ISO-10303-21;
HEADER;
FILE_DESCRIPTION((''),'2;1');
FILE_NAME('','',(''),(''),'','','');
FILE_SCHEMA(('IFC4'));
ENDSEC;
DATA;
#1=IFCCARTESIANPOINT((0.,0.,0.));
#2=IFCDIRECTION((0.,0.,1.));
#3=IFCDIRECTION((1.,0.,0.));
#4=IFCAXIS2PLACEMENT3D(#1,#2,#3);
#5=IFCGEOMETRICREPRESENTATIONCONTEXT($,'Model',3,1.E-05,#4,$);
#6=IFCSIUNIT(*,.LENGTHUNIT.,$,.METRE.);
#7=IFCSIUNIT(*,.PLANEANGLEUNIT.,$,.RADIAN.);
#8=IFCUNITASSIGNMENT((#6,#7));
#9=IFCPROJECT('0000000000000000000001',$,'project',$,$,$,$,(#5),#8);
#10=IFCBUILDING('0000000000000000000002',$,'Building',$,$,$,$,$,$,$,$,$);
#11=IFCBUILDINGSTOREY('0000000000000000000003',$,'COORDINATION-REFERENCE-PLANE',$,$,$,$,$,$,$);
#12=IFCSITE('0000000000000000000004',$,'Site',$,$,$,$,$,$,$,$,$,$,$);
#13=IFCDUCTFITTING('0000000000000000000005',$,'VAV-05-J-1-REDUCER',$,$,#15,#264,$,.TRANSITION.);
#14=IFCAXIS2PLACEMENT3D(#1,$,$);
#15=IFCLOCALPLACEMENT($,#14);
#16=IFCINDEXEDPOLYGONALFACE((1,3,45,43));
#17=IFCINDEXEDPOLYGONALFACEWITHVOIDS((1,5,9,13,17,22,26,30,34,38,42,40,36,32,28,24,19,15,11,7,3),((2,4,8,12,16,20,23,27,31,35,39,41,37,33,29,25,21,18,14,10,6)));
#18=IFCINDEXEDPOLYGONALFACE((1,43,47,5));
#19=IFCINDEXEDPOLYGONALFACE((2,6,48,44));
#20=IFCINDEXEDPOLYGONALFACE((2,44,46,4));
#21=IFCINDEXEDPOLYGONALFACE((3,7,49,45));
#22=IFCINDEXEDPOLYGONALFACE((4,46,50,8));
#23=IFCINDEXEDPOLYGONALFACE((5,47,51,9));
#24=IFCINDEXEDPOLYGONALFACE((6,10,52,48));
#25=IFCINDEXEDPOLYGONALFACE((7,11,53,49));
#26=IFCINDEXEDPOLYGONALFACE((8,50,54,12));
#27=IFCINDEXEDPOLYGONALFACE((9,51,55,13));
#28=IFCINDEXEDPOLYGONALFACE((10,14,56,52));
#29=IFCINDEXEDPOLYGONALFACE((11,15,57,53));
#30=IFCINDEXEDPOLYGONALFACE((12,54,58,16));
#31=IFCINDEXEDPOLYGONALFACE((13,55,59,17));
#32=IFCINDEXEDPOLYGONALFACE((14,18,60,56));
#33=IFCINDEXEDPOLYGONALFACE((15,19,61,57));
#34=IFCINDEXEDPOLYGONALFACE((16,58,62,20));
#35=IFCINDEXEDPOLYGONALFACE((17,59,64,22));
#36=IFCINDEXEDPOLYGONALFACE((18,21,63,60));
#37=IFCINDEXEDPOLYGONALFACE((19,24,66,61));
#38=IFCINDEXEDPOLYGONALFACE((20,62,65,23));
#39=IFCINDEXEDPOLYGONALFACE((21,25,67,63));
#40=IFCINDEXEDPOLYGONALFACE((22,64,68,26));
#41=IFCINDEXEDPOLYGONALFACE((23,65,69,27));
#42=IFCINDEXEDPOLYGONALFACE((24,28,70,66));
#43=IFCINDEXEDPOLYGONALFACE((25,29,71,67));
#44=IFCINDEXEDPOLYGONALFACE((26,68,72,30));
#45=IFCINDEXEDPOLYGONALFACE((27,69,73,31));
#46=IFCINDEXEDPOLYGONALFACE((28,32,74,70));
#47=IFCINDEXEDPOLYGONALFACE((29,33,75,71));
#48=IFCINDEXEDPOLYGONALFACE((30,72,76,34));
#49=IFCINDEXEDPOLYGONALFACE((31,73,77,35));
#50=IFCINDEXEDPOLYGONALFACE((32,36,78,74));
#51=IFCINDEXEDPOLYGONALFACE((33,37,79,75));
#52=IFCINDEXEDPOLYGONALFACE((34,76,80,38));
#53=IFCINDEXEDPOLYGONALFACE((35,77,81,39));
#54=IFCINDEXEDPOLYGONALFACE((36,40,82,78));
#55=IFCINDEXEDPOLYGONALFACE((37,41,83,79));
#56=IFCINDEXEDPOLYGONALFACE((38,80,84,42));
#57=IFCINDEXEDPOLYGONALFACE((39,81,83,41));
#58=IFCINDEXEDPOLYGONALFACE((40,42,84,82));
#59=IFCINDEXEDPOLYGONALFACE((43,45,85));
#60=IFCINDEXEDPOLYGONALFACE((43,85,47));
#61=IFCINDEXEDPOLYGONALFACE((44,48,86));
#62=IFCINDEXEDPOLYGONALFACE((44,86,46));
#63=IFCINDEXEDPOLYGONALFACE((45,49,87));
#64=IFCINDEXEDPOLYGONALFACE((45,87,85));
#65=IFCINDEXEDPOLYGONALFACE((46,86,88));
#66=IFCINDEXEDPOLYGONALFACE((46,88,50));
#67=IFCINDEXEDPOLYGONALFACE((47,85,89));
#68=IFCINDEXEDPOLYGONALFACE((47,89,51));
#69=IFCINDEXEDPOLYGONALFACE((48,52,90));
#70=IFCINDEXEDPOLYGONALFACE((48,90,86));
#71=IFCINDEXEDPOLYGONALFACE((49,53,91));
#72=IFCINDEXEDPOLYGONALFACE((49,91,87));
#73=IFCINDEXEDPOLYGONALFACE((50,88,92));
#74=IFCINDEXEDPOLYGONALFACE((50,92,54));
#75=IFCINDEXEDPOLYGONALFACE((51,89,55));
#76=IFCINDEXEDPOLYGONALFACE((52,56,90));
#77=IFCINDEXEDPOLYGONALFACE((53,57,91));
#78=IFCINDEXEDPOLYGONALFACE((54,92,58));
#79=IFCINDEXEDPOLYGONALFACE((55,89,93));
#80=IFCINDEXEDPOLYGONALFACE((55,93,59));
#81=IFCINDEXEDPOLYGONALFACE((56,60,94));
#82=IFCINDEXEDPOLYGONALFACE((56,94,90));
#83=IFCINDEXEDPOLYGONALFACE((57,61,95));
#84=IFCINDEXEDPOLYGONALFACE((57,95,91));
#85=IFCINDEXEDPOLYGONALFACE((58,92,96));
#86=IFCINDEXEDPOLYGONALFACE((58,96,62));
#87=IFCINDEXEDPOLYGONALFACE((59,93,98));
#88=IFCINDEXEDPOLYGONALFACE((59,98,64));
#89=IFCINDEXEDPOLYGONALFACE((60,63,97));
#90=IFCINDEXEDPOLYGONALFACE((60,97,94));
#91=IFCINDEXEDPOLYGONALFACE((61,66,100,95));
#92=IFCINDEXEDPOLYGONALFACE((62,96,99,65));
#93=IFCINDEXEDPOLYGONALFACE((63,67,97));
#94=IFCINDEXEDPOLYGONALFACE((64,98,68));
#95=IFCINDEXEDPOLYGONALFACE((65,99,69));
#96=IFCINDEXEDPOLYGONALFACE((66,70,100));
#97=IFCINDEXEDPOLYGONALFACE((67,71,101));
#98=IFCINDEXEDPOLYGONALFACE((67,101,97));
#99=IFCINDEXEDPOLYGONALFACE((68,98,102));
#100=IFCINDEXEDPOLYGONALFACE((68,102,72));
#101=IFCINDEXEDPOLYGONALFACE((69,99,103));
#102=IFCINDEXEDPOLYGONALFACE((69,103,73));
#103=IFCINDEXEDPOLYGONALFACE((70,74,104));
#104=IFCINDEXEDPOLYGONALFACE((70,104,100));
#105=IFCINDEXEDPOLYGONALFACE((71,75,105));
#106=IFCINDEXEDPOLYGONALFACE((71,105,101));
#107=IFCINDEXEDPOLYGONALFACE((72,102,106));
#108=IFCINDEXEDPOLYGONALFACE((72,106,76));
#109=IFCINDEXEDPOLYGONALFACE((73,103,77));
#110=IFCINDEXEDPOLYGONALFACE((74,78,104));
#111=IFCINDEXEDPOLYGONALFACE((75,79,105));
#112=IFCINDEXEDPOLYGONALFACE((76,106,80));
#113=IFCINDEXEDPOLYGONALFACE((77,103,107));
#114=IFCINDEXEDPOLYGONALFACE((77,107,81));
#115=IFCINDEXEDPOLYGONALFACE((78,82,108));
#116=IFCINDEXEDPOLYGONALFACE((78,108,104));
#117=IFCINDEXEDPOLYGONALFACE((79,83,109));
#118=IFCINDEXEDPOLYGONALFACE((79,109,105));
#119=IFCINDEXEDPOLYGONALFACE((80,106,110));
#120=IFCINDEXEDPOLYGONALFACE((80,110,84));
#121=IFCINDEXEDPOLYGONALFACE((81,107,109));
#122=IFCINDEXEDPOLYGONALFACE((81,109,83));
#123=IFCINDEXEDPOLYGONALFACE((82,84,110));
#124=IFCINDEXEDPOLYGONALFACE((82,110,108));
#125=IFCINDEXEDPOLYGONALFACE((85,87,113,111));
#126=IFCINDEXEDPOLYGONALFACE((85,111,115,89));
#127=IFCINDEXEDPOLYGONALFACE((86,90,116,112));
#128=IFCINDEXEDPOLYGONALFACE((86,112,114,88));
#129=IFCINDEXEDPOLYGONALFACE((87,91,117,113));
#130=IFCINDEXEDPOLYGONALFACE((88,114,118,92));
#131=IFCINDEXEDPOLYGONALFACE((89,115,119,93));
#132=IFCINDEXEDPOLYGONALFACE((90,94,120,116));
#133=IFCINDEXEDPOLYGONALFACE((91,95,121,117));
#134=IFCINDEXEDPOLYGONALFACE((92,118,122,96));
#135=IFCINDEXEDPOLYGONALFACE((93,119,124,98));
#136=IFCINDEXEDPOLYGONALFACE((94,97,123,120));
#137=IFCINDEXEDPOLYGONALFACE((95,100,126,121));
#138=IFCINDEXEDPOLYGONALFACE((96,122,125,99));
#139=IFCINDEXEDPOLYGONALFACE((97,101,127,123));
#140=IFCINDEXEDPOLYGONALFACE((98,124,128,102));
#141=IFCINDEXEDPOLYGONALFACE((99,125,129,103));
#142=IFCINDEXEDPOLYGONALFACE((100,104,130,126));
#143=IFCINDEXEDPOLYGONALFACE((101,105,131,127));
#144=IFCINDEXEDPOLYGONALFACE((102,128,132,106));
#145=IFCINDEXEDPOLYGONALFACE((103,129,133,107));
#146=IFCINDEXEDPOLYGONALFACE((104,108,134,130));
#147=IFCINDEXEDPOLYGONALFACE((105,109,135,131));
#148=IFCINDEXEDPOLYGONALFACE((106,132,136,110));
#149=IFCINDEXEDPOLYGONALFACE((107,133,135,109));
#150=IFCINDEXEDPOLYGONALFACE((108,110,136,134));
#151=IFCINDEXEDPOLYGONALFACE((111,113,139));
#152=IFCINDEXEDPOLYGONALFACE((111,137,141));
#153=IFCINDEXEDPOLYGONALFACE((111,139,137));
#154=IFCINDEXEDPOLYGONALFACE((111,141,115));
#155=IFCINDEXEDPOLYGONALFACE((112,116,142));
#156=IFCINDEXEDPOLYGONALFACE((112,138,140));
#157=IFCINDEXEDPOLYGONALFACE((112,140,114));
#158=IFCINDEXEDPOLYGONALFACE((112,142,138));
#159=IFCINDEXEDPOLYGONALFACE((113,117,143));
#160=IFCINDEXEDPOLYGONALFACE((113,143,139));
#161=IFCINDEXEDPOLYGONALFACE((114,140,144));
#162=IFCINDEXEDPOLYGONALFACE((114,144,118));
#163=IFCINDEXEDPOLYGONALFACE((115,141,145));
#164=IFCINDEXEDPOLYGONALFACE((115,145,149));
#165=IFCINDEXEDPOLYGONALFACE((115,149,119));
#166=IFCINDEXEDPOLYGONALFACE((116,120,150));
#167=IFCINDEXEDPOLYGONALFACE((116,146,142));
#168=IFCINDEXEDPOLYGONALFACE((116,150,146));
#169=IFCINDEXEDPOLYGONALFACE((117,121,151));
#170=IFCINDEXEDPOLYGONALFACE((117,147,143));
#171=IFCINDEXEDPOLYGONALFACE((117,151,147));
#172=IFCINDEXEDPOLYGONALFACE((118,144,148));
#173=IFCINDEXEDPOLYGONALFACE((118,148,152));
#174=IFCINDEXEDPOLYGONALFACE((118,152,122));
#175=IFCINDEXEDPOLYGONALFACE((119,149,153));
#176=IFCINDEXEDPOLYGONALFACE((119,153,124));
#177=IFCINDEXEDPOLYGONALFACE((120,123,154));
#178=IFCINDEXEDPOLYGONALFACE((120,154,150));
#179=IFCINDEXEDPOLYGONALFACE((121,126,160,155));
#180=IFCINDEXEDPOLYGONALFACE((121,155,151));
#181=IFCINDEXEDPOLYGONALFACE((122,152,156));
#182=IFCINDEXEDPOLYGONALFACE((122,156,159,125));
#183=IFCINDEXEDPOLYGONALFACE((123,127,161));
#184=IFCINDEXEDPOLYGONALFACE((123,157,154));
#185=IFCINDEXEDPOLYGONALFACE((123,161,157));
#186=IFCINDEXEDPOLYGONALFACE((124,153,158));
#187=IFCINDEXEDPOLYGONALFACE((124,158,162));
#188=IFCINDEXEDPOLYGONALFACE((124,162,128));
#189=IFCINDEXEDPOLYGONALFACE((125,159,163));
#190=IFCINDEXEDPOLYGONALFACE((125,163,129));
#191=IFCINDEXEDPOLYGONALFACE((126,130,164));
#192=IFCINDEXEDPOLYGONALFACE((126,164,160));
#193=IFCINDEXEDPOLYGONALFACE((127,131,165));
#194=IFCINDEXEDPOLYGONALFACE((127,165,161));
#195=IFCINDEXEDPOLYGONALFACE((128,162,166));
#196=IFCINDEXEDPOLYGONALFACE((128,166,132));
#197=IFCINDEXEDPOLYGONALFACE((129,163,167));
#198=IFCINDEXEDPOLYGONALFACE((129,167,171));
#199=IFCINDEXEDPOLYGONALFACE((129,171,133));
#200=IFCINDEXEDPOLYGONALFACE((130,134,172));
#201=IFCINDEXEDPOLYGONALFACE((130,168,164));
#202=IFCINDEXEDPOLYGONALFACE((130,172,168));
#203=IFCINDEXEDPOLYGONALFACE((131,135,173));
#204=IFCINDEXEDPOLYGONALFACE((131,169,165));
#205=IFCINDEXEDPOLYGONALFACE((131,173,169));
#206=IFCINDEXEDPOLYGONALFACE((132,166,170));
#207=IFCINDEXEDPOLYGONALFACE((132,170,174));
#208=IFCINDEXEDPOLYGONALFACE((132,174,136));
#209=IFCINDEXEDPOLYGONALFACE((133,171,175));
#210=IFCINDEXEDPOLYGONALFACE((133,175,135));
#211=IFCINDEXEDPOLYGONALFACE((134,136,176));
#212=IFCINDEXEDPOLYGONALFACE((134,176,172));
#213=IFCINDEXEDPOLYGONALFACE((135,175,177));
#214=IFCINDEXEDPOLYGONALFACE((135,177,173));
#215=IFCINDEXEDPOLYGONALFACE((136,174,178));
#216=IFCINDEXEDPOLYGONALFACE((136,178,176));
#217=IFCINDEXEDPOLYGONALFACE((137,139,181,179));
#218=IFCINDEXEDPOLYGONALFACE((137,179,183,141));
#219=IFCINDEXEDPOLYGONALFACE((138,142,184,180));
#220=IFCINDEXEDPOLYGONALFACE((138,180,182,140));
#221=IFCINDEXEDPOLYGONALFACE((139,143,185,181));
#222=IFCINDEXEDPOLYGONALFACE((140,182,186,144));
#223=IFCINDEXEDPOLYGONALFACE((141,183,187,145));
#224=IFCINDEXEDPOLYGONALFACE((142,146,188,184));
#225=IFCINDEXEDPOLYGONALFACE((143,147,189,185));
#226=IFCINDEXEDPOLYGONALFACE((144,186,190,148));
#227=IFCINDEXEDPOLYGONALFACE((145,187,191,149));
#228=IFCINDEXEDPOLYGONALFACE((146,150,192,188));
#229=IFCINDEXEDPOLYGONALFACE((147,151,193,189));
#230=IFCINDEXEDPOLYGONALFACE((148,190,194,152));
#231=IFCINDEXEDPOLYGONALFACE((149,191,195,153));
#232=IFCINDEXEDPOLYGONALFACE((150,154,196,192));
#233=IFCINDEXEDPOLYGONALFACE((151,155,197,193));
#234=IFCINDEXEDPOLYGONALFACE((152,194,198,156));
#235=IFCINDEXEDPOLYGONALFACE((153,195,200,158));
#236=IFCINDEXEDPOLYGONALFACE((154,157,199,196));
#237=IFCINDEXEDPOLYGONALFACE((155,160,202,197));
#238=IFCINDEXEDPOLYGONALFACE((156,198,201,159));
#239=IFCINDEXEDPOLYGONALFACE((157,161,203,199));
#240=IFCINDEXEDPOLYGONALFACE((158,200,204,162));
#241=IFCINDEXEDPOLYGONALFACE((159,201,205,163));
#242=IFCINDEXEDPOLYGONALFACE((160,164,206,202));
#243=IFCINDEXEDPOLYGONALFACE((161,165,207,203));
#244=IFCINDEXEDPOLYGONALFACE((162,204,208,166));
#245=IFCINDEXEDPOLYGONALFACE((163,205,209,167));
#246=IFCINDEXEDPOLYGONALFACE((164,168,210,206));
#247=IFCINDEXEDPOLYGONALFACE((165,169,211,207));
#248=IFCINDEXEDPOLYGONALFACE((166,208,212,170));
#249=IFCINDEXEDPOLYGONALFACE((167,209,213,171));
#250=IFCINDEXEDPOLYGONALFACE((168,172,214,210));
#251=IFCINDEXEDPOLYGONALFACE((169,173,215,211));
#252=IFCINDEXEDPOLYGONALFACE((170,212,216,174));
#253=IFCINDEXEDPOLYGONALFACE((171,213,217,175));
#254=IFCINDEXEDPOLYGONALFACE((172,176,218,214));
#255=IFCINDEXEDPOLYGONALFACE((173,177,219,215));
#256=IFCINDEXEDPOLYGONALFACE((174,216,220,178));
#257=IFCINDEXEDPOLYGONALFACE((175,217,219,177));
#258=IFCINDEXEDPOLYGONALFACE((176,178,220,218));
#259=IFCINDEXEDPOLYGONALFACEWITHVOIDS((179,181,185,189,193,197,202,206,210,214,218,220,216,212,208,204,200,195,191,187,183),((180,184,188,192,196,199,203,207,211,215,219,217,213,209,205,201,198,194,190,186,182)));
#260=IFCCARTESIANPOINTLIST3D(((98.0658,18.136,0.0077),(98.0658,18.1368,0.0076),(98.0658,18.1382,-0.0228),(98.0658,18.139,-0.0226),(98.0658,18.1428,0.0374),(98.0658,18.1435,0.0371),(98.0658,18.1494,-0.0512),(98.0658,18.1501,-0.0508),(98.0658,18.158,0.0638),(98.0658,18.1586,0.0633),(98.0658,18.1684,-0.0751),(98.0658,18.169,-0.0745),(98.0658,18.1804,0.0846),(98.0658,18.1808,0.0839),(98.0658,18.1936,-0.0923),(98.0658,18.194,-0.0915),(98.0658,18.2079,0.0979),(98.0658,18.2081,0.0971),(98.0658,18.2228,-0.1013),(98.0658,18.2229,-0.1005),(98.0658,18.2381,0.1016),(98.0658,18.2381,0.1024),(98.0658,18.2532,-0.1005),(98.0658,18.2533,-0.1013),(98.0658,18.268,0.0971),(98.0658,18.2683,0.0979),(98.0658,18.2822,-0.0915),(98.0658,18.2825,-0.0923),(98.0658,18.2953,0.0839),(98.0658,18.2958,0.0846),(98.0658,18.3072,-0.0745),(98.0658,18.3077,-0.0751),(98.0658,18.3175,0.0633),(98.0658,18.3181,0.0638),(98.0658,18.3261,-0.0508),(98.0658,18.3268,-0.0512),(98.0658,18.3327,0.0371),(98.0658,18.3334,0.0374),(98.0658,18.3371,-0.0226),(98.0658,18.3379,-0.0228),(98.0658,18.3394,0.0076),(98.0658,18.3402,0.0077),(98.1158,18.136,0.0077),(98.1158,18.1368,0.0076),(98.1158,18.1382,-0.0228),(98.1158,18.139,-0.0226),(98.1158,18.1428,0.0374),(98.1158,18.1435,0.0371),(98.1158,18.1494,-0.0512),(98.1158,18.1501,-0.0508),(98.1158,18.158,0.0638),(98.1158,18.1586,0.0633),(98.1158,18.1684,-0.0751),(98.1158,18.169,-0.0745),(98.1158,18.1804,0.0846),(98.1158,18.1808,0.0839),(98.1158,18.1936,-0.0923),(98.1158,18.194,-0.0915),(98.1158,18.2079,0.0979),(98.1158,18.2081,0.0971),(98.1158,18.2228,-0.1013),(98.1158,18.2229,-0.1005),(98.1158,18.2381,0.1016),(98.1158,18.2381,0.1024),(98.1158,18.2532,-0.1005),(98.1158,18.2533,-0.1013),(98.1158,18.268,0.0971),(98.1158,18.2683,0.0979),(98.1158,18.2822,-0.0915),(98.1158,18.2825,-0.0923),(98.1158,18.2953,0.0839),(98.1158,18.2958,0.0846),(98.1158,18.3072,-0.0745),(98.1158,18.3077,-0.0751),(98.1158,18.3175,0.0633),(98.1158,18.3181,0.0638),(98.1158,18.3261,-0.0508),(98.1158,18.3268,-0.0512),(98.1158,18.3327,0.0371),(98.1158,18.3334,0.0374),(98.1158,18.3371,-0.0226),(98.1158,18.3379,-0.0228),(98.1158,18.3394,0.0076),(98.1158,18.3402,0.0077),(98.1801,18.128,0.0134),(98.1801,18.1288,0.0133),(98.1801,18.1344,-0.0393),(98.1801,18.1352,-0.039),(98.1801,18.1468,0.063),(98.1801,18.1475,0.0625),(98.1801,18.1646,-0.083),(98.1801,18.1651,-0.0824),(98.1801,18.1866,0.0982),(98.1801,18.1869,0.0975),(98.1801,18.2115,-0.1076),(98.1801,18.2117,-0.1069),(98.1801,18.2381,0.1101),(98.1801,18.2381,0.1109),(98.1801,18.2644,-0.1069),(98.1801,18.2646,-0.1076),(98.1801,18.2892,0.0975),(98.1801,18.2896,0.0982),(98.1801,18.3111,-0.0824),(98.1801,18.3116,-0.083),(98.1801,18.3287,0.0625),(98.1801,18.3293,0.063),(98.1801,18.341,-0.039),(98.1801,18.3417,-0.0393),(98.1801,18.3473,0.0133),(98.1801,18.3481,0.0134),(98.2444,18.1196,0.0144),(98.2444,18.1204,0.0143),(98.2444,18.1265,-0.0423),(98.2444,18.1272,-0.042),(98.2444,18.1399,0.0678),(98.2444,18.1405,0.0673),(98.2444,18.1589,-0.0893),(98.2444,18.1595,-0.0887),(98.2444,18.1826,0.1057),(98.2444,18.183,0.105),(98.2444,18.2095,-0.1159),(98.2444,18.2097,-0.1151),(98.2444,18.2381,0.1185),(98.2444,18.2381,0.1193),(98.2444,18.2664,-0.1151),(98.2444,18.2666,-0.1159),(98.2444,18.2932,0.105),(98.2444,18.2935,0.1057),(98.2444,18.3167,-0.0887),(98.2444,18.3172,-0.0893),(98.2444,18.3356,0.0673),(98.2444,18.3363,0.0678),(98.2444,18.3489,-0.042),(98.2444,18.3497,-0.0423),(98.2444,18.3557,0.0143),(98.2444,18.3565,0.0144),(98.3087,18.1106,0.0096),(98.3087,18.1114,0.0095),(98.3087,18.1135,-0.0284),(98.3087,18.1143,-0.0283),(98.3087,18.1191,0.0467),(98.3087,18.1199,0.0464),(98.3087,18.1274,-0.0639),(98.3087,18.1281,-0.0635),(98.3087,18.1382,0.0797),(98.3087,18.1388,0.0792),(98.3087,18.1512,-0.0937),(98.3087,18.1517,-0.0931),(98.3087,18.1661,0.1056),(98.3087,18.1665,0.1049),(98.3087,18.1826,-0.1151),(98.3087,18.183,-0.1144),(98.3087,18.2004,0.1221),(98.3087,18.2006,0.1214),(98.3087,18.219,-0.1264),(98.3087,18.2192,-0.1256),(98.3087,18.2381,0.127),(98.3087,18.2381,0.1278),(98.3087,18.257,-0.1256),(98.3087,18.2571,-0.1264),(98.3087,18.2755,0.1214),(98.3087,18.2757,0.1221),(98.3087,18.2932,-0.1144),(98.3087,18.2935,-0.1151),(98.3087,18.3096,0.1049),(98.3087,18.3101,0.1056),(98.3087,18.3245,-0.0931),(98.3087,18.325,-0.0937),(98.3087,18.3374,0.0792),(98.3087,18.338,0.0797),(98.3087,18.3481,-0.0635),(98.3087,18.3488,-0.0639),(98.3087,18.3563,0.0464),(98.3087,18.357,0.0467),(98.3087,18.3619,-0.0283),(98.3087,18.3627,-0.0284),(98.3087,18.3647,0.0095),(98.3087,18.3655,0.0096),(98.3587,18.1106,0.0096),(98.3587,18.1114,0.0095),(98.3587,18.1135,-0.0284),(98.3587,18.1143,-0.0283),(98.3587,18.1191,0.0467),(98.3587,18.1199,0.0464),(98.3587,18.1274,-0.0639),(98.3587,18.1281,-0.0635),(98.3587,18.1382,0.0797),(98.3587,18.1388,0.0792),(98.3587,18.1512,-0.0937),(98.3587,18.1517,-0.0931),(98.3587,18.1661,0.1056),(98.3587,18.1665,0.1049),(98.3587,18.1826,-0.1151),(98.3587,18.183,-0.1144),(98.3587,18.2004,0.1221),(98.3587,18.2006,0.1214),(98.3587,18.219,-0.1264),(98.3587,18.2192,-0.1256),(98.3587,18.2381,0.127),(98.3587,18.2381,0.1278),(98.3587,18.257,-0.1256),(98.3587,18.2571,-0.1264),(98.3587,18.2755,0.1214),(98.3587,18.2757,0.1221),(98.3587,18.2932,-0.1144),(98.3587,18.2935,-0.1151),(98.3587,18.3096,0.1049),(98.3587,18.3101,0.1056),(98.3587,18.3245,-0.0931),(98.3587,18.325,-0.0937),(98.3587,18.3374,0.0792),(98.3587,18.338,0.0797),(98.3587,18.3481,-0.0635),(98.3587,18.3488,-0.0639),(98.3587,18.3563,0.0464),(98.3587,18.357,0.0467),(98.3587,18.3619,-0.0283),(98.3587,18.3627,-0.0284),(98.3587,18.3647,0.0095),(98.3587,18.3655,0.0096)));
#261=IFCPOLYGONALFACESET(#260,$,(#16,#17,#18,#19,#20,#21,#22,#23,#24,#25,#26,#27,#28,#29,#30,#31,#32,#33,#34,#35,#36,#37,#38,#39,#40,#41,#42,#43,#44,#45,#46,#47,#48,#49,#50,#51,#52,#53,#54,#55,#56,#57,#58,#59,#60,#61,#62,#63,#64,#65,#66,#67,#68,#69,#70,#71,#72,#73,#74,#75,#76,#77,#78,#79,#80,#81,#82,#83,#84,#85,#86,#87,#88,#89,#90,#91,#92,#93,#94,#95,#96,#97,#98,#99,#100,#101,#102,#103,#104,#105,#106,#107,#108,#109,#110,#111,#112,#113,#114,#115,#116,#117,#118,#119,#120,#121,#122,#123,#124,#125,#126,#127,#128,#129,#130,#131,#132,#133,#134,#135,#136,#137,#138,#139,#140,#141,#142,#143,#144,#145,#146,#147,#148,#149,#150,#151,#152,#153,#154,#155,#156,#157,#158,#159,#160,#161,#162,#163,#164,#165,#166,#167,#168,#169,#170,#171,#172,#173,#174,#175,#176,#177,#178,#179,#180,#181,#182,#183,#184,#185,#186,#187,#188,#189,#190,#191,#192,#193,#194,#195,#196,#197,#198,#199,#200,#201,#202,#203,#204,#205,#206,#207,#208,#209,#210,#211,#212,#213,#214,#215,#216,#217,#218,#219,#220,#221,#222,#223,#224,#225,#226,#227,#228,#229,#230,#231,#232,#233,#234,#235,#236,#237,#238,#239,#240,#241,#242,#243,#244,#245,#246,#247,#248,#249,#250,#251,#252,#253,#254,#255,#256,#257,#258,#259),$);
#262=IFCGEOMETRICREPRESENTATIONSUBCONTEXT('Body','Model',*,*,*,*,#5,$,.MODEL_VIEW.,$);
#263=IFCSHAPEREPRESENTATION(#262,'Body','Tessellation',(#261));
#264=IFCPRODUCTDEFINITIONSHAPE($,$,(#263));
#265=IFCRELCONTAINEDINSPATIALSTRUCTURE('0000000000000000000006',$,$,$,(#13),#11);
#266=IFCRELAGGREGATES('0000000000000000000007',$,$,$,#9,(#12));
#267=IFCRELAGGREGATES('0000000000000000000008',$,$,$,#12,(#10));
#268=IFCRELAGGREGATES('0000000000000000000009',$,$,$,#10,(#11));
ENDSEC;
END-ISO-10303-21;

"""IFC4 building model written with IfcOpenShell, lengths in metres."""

from ifc_helpers import new_model, entity, si_unit, frame, origin_with_axes, place, context, subcontext, project, spatial, element, save


model = new_model("IFC4")

# Units and contexts
model_context_1 = context("Model", 3, precision=1e-05, world=origin_with_axes())
body_context_1 = subcontext(model_context_1, "Body", "Model", "MODEL_VIEW")
ifc_project = project(units=[si_unit("LENGTHUNIT", "METRE"), si_unit("PLANEANGLEUNIT", "RADIAN")], contexts=[model_context_1])

# Site, building, storey
site = spatial("IfcSite", under=ifc_project, Name="Site")
building = spatial("IfcBuilding", under=site, Name="Building")
storey = spatial("IfcBuildingStorey", under=building, Name="COORDINATION-REFERENCE-PLANE")

# Duct fitting
for number, where, z_axis, x_axis, name in (
    (1, (98.3587, 18.2381, 0.0), (0.0, -1.0, 0.0), (0.0, 0.0, 1.0), "VAV-05-J-1-REDUCER"),
):
    element("IfcDuctFitting", number, at=place(None, frame(where, z_axis=z_axis, x_axis=x_axis)), inside=storey, Name=name, PredefinedType="TRANSITION", context=body_context_1, shape_type="SweptSolid", body=[
        entity("IfcRevolvedAreaSolid", entity("IfcArbitraryClosedProfileDef", "AREA", None, entity("IfcPolyline", [entity("IfcCartesianPoint", [0.1278, 0.0]), entity("IfcCartesianPoint", [0.1278, 0.05]), entity("IfcCartesianPoint", [0.1024, 0.2429]), entity("IfcCartesianPoint", [0.1024, 0.2929]), entity("IfcCartesianPoint", [0.1016, 0.2929]), entity("IfcCartesianPoint", [0.1016, 0.2429]), entity("IfcCartesianPoint", [0.127, 0.05]), entity("IfcCartesianPoint", [0.127, 0.0]), entity("IfcCartesianPoint", [0.1278, 0.0])])), entity("IfcAxis2Placement3D", entity("IfcCartesianPoint", [0.0, 0.0, 0.0])), entity("IfcAxis1Placement", entity("IfcCartesianPoint", [0.0, 0.0, 0.0]), entity("IfcDirection", [0.0, 1.0, 0.0])), 6.283185),
    ])

save(model, "model.ifc")
